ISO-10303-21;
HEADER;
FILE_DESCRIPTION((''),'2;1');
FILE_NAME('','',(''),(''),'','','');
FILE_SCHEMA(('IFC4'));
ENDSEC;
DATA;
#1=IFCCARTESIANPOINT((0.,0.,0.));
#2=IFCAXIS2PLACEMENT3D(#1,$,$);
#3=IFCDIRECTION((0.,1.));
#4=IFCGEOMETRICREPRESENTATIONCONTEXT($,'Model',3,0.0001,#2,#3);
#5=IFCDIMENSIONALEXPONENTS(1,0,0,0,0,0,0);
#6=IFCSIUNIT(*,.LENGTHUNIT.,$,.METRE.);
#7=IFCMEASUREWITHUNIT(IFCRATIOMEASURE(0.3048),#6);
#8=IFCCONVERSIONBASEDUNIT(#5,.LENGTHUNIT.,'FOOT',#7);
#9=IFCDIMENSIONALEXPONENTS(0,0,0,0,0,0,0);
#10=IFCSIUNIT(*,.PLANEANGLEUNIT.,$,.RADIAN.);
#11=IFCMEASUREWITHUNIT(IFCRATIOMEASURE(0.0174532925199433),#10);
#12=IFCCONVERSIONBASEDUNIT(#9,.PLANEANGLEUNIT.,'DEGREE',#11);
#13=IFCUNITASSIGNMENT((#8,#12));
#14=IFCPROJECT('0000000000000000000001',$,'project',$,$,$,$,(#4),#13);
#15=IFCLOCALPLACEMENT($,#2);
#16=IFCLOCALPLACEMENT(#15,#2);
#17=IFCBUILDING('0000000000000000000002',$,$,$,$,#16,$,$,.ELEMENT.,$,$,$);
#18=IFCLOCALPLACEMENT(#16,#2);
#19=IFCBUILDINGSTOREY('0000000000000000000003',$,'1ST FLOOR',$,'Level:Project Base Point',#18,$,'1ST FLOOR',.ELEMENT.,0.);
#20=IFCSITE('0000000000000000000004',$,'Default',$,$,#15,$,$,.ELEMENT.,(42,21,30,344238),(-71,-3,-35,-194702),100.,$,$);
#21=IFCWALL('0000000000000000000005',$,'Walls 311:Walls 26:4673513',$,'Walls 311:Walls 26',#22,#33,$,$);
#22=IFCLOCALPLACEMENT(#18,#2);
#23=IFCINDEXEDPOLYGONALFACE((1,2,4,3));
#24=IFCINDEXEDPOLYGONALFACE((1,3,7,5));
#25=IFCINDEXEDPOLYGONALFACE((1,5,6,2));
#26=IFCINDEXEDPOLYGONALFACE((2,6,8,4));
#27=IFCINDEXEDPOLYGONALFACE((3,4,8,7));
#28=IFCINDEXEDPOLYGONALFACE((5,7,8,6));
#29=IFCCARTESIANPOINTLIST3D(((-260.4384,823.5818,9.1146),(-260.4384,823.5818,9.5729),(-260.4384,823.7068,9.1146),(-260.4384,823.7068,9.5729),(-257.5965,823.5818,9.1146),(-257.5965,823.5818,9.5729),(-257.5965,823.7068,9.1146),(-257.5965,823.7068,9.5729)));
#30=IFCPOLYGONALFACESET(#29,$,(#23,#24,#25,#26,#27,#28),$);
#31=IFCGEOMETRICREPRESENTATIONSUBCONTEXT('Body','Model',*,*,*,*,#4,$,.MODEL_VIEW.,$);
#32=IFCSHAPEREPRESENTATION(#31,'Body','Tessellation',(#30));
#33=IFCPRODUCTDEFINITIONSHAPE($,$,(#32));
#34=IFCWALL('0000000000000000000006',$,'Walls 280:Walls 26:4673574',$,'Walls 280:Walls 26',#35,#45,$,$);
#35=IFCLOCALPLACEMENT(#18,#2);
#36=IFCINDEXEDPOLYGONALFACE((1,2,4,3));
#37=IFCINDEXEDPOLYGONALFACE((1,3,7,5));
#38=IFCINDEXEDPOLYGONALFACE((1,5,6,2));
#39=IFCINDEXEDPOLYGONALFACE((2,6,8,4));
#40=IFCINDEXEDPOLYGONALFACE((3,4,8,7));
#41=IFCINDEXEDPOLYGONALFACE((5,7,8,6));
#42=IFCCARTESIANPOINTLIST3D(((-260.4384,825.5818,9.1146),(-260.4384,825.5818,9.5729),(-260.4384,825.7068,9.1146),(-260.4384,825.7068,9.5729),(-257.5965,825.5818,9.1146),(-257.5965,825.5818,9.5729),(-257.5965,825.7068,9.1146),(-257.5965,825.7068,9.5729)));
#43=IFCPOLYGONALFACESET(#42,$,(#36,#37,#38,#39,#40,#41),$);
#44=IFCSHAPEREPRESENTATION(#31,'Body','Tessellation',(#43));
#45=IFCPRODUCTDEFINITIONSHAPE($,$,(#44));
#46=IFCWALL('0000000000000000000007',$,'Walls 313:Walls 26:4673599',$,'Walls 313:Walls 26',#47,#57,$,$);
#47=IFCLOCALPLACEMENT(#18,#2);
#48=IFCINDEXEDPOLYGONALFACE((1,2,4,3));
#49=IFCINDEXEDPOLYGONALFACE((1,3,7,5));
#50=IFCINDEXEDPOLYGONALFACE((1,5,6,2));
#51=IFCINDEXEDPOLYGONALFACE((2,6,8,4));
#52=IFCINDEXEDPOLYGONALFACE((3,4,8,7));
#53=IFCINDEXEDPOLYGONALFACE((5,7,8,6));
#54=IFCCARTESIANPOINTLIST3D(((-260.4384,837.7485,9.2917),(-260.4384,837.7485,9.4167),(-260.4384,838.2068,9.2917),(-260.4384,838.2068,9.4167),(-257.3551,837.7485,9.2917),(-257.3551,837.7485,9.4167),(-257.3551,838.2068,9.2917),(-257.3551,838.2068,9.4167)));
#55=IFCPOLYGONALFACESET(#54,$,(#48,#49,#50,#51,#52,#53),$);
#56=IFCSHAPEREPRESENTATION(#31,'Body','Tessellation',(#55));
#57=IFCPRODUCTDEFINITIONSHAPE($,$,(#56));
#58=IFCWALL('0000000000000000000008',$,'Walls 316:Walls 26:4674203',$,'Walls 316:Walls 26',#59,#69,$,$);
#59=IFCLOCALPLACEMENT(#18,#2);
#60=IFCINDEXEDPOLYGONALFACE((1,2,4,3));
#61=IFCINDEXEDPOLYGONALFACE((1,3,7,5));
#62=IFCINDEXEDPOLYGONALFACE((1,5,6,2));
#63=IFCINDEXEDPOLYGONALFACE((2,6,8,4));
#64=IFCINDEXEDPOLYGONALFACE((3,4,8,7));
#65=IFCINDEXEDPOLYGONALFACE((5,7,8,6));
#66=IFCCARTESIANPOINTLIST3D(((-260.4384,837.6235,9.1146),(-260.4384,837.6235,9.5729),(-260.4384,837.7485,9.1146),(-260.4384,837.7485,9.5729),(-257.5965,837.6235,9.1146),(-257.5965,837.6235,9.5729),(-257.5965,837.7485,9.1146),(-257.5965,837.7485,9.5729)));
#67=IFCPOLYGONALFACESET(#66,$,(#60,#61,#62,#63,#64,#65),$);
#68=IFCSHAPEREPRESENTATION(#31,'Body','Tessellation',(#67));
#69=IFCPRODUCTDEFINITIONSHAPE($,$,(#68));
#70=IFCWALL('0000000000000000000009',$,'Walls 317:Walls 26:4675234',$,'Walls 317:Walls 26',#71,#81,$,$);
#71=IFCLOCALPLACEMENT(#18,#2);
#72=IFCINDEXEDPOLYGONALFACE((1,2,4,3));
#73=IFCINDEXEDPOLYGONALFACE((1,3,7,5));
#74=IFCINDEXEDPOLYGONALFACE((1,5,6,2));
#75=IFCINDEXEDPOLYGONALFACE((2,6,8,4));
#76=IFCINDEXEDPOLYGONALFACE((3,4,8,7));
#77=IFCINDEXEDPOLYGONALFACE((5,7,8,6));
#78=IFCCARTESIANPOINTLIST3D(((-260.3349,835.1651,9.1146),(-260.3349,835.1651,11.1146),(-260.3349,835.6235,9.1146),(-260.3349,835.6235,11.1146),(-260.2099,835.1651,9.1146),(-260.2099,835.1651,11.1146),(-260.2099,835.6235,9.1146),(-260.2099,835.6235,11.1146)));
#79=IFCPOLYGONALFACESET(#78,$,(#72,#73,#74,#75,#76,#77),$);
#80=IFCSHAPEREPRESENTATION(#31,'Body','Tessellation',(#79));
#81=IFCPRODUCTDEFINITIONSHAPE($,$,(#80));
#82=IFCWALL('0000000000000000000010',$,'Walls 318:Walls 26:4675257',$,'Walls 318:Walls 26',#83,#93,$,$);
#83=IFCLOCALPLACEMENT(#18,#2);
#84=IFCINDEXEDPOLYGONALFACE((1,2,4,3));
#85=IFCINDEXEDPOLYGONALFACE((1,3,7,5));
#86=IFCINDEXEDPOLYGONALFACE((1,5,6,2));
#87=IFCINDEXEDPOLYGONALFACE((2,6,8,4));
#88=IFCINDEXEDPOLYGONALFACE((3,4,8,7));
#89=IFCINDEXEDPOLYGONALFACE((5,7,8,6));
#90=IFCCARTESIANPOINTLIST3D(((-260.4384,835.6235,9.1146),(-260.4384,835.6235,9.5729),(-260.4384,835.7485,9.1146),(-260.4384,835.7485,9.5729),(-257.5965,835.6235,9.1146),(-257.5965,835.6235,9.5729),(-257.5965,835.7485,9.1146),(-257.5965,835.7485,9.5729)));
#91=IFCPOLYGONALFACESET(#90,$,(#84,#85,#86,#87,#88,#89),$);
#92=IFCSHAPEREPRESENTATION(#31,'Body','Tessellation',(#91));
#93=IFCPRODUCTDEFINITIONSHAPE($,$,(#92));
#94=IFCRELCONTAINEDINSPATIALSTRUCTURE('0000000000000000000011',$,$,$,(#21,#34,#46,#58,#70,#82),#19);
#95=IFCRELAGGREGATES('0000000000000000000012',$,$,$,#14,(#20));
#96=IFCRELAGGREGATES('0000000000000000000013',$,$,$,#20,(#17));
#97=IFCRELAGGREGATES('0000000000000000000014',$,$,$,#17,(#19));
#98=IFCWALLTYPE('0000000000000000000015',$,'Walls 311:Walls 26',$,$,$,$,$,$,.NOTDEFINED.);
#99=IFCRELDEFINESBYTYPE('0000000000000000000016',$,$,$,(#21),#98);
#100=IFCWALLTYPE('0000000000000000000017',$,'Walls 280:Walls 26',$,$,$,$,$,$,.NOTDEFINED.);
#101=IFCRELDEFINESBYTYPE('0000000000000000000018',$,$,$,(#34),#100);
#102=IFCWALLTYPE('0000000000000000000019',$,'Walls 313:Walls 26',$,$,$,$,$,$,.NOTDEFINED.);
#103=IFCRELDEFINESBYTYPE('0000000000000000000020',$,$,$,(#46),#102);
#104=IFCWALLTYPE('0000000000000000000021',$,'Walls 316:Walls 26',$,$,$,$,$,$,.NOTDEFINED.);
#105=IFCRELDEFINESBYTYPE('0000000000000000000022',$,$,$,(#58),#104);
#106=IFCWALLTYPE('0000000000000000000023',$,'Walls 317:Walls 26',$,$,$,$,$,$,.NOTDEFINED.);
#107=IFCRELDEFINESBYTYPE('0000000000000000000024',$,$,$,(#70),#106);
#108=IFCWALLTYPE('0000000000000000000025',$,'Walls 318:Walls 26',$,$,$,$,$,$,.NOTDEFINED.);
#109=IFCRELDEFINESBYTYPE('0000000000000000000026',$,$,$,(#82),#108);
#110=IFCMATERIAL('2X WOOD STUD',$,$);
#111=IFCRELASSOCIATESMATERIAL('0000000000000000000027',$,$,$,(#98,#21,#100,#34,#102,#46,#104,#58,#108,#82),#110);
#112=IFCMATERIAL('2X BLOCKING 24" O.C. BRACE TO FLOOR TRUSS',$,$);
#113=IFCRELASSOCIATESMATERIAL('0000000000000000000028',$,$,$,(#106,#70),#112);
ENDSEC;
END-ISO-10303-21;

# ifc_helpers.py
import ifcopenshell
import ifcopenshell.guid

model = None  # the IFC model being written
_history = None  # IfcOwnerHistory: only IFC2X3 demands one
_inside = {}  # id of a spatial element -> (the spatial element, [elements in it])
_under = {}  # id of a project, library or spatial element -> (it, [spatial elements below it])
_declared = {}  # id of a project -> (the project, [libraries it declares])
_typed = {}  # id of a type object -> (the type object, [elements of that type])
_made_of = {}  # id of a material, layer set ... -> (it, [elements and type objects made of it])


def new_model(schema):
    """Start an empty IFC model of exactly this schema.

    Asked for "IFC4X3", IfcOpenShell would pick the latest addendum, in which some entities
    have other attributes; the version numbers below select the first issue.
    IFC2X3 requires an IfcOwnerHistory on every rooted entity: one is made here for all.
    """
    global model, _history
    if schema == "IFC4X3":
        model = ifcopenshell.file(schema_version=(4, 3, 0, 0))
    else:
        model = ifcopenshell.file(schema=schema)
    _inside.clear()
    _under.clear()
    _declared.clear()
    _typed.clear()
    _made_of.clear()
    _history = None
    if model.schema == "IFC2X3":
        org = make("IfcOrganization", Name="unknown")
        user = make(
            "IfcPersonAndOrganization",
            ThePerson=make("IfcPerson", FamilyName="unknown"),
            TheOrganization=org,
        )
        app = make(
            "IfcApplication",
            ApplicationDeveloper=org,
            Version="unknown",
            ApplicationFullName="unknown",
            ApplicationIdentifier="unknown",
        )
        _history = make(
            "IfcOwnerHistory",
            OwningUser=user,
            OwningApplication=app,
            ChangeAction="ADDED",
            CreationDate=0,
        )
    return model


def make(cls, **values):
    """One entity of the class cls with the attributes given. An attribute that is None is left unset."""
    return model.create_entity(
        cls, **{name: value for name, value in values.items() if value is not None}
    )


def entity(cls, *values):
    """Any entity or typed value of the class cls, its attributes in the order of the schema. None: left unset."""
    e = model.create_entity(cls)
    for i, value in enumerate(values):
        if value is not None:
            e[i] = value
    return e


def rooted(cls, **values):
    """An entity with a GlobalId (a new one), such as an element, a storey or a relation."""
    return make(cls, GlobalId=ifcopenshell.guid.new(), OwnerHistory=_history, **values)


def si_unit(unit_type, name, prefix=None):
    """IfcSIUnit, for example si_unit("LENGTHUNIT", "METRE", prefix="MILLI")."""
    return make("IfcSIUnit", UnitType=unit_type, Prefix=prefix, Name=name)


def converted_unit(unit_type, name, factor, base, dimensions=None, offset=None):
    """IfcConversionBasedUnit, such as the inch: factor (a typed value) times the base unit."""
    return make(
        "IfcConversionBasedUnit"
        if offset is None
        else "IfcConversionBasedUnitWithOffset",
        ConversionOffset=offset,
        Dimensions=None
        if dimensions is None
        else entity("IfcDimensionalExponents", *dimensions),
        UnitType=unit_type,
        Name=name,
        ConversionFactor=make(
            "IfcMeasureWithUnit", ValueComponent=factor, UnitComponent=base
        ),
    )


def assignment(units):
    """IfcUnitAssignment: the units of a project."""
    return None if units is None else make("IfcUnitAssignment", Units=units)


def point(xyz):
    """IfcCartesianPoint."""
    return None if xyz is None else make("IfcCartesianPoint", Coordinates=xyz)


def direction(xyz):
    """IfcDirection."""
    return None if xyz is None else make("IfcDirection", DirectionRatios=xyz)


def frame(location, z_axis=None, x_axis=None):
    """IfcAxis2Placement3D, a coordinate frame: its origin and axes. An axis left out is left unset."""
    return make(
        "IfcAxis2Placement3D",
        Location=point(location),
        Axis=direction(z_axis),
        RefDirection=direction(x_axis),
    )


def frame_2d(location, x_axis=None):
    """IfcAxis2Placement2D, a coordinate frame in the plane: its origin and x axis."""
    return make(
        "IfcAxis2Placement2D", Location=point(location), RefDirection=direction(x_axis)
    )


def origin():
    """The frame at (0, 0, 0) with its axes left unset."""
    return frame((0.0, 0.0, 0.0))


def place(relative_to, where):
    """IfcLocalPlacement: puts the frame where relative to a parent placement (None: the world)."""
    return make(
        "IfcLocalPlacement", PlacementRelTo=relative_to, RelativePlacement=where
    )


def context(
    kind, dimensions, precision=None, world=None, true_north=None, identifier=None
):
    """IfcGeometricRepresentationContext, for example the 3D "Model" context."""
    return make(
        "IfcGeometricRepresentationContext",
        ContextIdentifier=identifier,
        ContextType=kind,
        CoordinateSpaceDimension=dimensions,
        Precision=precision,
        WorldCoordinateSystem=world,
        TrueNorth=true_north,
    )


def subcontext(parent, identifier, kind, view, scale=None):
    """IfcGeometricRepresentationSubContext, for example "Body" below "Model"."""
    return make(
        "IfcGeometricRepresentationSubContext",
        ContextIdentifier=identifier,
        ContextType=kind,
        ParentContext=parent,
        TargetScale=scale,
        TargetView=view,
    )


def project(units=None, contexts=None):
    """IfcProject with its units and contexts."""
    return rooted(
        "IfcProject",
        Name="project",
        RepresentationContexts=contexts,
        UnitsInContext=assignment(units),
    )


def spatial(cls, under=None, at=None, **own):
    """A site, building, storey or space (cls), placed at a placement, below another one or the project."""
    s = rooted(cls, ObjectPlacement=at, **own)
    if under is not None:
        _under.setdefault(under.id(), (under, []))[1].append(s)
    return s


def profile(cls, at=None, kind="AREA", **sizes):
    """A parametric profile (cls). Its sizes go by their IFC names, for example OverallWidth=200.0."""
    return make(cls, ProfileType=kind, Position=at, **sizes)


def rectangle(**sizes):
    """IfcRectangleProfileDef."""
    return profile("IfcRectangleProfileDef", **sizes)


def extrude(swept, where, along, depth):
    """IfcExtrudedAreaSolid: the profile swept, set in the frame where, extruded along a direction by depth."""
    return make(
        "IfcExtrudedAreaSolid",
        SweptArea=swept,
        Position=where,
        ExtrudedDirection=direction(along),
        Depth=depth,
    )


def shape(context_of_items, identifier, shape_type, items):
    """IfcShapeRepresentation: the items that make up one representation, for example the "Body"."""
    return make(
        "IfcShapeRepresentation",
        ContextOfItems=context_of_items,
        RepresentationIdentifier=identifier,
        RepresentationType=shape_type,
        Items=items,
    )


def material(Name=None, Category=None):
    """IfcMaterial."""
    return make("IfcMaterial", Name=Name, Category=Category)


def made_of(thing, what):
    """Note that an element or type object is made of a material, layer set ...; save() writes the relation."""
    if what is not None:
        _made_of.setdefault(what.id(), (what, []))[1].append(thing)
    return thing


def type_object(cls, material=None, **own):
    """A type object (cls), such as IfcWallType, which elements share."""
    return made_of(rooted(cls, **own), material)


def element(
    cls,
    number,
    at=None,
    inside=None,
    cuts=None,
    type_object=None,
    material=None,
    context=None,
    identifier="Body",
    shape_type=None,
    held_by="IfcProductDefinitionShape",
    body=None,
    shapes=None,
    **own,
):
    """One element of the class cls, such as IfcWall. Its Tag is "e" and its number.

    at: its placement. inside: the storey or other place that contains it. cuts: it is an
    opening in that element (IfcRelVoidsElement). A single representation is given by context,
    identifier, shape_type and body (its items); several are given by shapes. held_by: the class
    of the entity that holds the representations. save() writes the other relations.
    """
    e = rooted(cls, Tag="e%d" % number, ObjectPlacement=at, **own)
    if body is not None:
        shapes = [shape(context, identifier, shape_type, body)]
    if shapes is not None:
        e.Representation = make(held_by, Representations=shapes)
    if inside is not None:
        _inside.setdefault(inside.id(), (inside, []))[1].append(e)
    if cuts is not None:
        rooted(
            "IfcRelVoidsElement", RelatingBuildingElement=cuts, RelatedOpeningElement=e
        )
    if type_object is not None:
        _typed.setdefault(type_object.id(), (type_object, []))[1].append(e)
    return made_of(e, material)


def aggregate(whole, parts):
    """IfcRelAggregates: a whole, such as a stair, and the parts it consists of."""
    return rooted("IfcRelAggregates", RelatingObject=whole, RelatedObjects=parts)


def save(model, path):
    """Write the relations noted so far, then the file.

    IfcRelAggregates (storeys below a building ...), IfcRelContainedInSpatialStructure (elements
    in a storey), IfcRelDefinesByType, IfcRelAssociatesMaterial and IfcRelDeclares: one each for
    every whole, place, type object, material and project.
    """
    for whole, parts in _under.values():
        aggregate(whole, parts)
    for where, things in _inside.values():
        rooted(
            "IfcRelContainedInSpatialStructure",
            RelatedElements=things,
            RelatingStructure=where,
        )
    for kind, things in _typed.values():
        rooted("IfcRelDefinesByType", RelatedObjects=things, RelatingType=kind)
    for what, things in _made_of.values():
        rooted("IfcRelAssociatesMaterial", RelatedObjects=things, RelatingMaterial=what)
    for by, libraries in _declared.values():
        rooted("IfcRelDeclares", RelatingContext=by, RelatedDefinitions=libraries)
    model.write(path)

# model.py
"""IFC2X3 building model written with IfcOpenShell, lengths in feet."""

from ifc_helpers import new_model, entity, si_unit, converted_unit, direction, frame, frame_2d, origin, place, context, subcontext, project, spatial, rectangle, extrude, material, type_object, element, save


model = new_model("IFC2X3")

# Units and contexts
model_context = context("Model", 3, precision=0.0001, world=origin(), true_north=direction((0.0, 1.0)))
body_context = subcontext(model_context, "Body", "Model", "MODEL_VIEW")
ifc_project = project(units=[converted_unit("LENGTHUNIT", "FOOT", entity("IfcRatioMeasure", 0.3048), si_unit("LENGTHUNIT", "METRE"), dimensions=[1, 0, 0, 0, 0, 0, 0]), converted_unit("PLANEANGLEUNIT", "DEGREE", entity("IfcRatioMeasure", 0.0174532925199433), si_unit("PLANEANGLEUNIT", "RADIAN"), dimensions=[0, 0, 0, 0, 0, 0, 0])], contexts=[model_context])

# Site, building, storey
site_placement = place(None, origin())
site = spatial("IfcSite", under=ifc_project, at=site_placement, Name="Default", CompositionType="ELEMENT", RefLatitude=(42, 21, 30, 344238), RefLongitude=(-71, -3, -35, -194702), RefElevation=100.0)
building_placement = place(site_placement, origin())
building = spatial("IfcBuilding", under=site, at=building_placement, CompositionType="ELEMENT")
storey_placement = place(building_placement, origin())
storey = spatial("IfcBuildingStorey", under=building, at=storey_placement, Name="1ST FLOOR", ObjectType="Level:Project Base Point", LongName="1ST FLOOR", CompositionType="ELEMENT", Elevation=0.0)

# Walls
ifc_material_1 = material(Name="2X BLOCKING 24\" O.C. BRACE TO FLOOR TRUSS")
ifc_material_2 = material(Name="2X WOOD STUD")
wall_type_1 = type_object("IfcWallType", Name="Walls 311:Walls 26", PredefinedType="NOTDEFINED", material=ifc_material_2)
wall_1_placement = place(storey_placement, frame((-260.4384, 823.5818, 9.1146)))
element("IfcWall", 1, at=wall_1_placement, inside=storey, type_object=wall_type_1, material=ifc_material_2, Name="Walls 311:Walls 26:4673513", ObjectType="Walls 311:Walls 26", context=body_context, shape_type="SweptSolid", body=[
    extrude(rectangle(XDim=2.8419, YDim=0.125, at=frame_2d((0.0, 0.0), x_axis=(1.0, 0.0))), frame((1.421, 0.0625, 0.0), z_axis=(0.0, 0.0, 1.0), x_axis=(-1.0, 0.0, 0.0)), (0.0, 0.0, 1.0), 0.4583),
])
wall_type_2 = type_object("IfcWallType", Name="Walls 280:Walls 26", PredefinedType="NOTDEFINED", material=ifc_material_2)
wall_2_placement = place(storey_placement, frame((-260.4384, 825.5818, 9.1146)))
element("IfcWall", 2, at=wall_2_placement, inside=storey, type_object=wall_type_2, material=ifc_material_2, Name="Walls 280:Walls 26:4673574", ObjectType="Walls 280:Walls 26", context=body_context, shape_type="SweptSolid", body=[
    extrude(rectangle(XDim=2.8419, YDim=0.125, at=frame_2d((0.0, 0.0), x_axis=(1.0, 0.0))), frame((1.421, 0.0625, 0.0), z_axis=(0.0, 0.0, 1.0), x_axis=(-1.0, 0.0, 0.0)), (0.0, 0.0, 1.0), 0.4583),
])
wall_type_3 = type_object("IfcWallType", Name="Walls 313:Walls 26", PredefinedType="NOTDEFINED", material=ifc_material_2)
wall_3_placement = place(storey_placement, frame((-260.4384, 837.7485, 9.2917)))
element("IfcWall", 3, at=wall_3_placement, inside=storey, type_object=wall_type_3, material=ifc_material_2, Name="Walls 313:Walls 26:4673599", ObjectType="Walls 313:Walls 26", context=body_context, shape_type="SweptSolid", body=[
    extrude(rectangle(XDim=3.0833, YDim=0.4583, at=frame_2d((0.0, 0.0), x_axis=(1.0, 0.0))), frame((1.5417, 0.2292, 0.0), z_axis=(0.0, 0.0, 1.0), x_axis=(-1.0, 0.0, 0.0)), (0.0, 0.0, 1.0), 0.125),
])
wall_type_4 = type_object("IfcWallType", Name="Walls 316:Walls 26", PredefinedType="NOTDEFINED", material=ifc_material_2)
wall_4_placement = place(storey_placement, frame((-260.4384, 837.6235, 9.1146)))
element("IfcWall", 4, at=wall_4_placement, inside=storey, type_object=wall_type_4, material=ifc_material_2, Name="Walls 316:Walls 26:4674203", ObjectType="Walls 316:Walls 26", context=body_context, shape_type="SweptSolid", body=[
    extrude(rectangle(XDim=2.8419, YDim=0.125, at=frame_2d((0.0, 0.0), x_axis=(1.0, 0.0))), frame((1.421, 0.0625, 0.0), z_axis=(0.0, 0.0, 1.0), x_axis=(-1.0, 0.0, 0.0)), (0.0, 0.0, 1.0), 0.4583),
])
wall_type_5 = type_object("IfcWallType", Name="Walls 317:Walls 26", PredefinedType="NOTDEFINED", material=ifc_material_1)
wall_5_placement = place(storey_placement, frame((-260.3349, 835.1651, 9.1146), z_axis=(0.0, 0.0, 1.0), x_axis=(0.0, 1.0, 0.0)))
element("IfcWall", 5, at=wall_5_placement, inside=storey, type_object=wall_type_5, material=ifc_material_1, Name="Walls 317:Walls 26:4675234", ObjectType="Walls 317:Walls 26", context=body_context, shape_type="SweptSolid", body=[
    extrude(rectangle(XDim=0.4583, YDim=0.125, at=frame_2d((0.0, 0.0), x_axis=(1.0, 0.0))), frame((0.2292, -0.0625, 0.0)), (0.0, 0.0, 1.0), 2.0),
])
wall_type_6 = type_object("IfcWallType", Name="Walls 318:Walls 26", PredefinedType="NOTDEFINED", material=ifc_material_2)
wall_6_placement = place(storey_placement, frame((-260.4384, 835.6235, 9.1146)))
element("IfcWall", 6, at=wall_6_placement, inside=storey, type_object=wall_type_6, material=ifc_material_2, Name="Walls 318:Walls 26:4675257", ObjectType="Walls 318:Walls 26", context=body_context, shape_type="SweptSolid", body=[
    extrude(rectangle(XDim=2.8419, YDim=0.125, at=frame_2d((0.0, 0.0), x_axis=(1.0, 0.0))), frame((1.421, 0.0625, 0.0), z_axis=(0.0, 0.0, 1.0), x_axis=(-1.0, 0.0, 0.0)), (0.0, 0.0, 1.0), 0.4583),
])

save(model, "model.ifc")
